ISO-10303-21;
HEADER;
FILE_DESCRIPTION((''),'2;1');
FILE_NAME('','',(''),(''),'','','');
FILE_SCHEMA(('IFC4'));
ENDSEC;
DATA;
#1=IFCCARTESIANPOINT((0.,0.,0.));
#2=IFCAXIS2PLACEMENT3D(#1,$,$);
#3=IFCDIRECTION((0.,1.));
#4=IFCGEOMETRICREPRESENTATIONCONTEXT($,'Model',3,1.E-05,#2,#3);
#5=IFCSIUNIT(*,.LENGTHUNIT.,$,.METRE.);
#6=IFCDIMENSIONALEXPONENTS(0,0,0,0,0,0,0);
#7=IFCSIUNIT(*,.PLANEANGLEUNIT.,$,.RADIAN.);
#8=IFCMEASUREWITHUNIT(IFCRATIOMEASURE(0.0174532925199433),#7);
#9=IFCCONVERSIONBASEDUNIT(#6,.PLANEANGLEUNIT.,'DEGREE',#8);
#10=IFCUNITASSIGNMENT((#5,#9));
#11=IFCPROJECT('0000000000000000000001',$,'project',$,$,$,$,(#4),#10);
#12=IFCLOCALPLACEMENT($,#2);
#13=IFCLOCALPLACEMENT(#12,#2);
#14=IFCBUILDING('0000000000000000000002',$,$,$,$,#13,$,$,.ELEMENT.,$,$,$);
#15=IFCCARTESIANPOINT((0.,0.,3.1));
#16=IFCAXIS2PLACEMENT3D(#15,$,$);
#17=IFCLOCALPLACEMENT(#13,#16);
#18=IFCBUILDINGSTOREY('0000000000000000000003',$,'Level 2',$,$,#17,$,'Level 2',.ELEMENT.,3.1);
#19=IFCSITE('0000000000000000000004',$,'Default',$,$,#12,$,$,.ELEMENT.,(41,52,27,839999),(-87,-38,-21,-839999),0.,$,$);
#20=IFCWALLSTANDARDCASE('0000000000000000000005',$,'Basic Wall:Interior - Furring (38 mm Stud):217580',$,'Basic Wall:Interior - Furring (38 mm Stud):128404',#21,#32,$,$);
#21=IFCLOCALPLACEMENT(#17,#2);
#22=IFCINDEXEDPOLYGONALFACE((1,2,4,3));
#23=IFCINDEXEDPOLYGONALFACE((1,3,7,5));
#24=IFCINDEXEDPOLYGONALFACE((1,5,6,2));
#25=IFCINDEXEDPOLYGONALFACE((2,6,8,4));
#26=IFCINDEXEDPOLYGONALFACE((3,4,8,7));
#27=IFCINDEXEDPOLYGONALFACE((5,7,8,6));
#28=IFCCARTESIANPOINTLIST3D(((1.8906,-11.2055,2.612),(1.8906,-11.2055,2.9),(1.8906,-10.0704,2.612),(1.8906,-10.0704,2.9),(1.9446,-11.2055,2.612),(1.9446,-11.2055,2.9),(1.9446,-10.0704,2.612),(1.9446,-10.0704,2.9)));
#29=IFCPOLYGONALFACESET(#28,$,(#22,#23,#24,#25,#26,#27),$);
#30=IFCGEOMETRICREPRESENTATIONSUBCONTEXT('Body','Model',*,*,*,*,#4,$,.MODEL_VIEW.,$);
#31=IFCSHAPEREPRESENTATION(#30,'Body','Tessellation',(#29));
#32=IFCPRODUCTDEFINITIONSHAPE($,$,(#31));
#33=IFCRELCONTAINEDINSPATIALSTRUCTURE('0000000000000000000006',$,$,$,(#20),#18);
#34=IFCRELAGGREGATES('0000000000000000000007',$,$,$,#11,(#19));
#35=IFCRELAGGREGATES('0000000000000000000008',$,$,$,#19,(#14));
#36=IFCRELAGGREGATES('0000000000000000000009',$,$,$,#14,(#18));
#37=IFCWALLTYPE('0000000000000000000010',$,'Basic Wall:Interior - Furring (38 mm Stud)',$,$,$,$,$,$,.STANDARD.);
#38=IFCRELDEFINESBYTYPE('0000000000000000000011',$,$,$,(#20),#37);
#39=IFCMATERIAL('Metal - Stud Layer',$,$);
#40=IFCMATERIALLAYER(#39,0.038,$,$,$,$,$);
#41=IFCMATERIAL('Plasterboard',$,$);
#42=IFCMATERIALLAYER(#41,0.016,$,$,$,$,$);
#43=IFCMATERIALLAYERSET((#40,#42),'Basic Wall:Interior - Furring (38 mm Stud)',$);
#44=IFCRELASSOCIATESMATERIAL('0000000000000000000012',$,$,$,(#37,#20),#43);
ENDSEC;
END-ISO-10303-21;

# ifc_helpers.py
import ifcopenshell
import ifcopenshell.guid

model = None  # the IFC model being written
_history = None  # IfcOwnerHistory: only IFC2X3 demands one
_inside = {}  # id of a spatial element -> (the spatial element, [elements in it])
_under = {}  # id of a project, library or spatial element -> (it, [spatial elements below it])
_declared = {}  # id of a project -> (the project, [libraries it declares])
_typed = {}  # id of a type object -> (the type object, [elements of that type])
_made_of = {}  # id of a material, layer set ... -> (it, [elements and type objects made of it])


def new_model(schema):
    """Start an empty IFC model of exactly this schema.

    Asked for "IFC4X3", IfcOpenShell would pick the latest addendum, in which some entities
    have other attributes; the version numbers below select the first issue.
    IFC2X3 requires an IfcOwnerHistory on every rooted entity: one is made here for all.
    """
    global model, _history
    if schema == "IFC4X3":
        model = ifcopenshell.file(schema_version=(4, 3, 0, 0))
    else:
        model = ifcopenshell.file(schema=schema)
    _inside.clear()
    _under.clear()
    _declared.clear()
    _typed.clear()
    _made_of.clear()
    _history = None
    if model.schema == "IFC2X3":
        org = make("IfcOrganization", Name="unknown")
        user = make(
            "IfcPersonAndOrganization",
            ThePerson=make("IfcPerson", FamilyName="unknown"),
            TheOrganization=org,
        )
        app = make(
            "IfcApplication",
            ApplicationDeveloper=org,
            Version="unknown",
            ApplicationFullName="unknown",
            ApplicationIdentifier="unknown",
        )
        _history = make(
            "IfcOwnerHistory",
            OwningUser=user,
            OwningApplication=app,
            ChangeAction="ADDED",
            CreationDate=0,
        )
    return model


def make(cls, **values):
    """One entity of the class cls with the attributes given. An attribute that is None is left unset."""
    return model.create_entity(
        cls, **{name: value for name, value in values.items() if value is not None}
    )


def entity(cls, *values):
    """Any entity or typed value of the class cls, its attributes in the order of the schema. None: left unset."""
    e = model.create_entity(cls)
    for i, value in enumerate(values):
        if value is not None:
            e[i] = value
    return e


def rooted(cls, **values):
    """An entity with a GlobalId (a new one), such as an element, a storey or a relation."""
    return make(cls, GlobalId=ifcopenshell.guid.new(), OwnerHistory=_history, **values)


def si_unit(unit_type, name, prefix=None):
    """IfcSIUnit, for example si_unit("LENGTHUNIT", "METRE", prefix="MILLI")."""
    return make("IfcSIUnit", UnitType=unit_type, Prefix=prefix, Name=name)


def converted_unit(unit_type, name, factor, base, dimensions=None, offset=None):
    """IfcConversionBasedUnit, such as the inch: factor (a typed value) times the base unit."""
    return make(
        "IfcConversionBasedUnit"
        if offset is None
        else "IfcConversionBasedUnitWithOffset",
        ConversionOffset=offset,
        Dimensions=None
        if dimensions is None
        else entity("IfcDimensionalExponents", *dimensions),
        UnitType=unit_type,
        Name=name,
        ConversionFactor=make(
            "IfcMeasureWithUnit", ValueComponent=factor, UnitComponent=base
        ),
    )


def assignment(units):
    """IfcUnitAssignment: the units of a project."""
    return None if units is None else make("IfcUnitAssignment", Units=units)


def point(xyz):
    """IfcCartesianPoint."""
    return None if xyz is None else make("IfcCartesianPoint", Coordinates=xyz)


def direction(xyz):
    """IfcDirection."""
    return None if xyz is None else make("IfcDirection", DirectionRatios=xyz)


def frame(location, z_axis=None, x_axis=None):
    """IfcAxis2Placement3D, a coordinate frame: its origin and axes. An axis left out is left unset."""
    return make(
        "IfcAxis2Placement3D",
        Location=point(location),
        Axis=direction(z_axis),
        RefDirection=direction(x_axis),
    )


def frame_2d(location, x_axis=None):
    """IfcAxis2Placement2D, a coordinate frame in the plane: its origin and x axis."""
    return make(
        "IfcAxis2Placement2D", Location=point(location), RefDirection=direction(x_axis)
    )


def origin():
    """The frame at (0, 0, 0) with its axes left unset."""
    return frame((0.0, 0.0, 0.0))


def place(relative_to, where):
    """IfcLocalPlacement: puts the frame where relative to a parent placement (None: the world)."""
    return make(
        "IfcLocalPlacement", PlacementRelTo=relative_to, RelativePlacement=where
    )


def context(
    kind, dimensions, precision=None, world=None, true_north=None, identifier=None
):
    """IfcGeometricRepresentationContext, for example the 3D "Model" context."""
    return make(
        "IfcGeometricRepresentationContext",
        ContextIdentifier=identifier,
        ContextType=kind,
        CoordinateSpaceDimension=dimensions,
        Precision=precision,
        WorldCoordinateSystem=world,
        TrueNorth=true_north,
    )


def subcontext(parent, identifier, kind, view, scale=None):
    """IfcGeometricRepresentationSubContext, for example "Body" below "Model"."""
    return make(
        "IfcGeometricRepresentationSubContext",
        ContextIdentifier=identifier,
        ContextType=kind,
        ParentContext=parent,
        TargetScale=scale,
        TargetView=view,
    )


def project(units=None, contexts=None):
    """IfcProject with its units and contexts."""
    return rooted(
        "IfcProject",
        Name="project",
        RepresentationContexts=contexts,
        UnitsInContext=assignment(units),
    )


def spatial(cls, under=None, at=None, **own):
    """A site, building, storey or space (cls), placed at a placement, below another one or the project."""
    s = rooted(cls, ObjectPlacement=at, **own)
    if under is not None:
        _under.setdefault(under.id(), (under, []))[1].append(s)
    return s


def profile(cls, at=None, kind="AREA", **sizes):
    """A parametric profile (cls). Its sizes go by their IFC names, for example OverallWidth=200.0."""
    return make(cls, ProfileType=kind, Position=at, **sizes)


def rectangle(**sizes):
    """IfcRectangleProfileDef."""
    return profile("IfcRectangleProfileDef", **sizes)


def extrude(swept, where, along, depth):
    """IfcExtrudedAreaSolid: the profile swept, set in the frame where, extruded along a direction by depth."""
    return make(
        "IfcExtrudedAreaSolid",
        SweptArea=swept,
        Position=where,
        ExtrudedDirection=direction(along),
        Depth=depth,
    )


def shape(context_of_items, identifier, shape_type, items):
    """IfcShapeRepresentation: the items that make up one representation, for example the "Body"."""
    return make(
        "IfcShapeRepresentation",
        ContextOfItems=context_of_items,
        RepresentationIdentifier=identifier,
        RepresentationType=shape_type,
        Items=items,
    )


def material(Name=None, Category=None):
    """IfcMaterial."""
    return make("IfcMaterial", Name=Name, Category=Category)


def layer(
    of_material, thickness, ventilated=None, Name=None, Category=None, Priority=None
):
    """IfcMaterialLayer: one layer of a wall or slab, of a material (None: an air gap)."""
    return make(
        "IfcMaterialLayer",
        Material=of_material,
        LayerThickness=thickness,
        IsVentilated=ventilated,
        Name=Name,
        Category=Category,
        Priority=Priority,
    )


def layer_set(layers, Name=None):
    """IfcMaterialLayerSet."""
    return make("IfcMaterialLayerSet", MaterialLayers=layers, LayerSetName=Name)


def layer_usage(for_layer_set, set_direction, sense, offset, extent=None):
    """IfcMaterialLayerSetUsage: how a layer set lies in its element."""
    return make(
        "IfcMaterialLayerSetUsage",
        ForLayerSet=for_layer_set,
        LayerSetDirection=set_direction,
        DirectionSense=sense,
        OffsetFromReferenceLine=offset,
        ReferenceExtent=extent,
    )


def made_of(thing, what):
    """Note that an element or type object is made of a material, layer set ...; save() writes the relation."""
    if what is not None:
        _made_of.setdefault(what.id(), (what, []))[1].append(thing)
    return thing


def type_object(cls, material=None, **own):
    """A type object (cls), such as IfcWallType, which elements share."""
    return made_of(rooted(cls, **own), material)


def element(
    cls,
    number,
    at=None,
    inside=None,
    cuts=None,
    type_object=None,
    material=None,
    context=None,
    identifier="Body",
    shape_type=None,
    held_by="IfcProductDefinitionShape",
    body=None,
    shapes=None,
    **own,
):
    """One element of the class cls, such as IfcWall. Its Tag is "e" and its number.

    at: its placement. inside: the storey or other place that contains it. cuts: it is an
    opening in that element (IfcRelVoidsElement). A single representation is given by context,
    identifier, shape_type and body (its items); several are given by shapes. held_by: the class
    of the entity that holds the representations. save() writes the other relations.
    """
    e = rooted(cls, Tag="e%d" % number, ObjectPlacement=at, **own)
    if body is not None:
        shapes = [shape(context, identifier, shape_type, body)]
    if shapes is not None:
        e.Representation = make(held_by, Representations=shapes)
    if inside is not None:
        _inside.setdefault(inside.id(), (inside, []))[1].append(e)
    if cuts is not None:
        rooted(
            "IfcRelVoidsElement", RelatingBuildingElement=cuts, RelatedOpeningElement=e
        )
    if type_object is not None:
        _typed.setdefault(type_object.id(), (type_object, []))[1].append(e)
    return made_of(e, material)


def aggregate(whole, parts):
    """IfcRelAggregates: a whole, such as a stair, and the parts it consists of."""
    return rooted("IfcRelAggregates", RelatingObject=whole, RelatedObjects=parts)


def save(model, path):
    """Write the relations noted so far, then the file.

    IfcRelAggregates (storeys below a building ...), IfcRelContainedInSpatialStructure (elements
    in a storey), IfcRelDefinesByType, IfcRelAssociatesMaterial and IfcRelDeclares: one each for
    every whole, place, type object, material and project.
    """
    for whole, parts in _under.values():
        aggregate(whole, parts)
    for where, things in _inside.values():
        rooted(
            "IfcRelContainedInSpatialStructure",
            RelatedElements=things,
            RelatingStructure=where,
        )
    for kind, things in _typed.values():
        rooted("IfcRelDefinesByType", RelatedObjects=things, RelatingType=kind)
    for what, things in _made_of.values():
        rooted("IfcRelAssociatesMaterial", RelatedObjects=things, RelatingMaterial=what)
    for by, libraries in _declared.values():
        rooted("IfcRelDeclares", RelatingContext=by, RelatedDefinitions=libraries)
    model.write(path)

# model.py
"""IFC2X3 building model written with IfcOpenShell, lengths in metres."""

from ifc_helpers import new_model, entity, si_unit, converted_unit, direction, frame, frame_2d, origin, place, context, subcontext, project, spatial, rectangle, extrude, material, layer, layer_set, layer_usage, type_object, element, save


model = new_model("IFC2X3")

# Units and contexts
model_context = context("Model", 3, precision=1e-05, world=origin(), true_north=direction((0.0, 1.0)))
body_context = subcontext(model_context, "Body", "Model", "MODEL_VIEW")
ifc_project = project(units=[si_unit("LENGTHUNIT", "METRE"), converted_unit("PLANEANGLEUNIT", "DEGREE", entity("IfcRatioMeasure", 0.0174532925199433), si_unit("PLANEANGLEUNIT", "RADIAN"), dimensions=[0, 0, 0, 0, 0, 0, 0])], contexts=[model_context])

# Site, building, storey
site_placement = place(None, origin())
site = spatial("IfcSite", under=ifc_project, at=site_placement, Name="Default", CompositionType="ELEMENT", RefLatitude=(41, 52, 27, 839999), RefLongitude=(-87, -38, -21, -839999), RefElevation=0.0)
building_placement = place(site_placement, origin())
building = spatial("IfcBuilding", under=site, at=building_placement, CompositionType="ELEMENT")
storey_placement = place(building_placement, frame((0.0, 0.0, 3.1)))
storey = spatial("IfcBuildingStorey", under=building, at=storey_placement, Name="Level 2", LongName="Level 2", CompositionType="ELEMENT", Elevation=3.1)

# Shared definitions
ifc_material_1 = material(Name="Plasterboard")
ifc_material_2 = material(Name="Metal - Stud Layer")

# Wall
ifc_layer_1 = layer(ifc_material_2, 0.038)
ifc_layer_2 = layer(ifc_material_1, 0.016)
ifc_layer_set_1 = layer_set([ifc_layer_1, ifc_layer_2], Name="Basic Wall:Interior - Furring (38 mm Stud)")
wall_type_1 = type_object("IfcWallType", Name="Basic Wall:Interior - Furring (38 mm Stud)", PredefinedType="STANDARD", material=ifc_layer_set_1)
ifc_layer_usage_1 = layer_usage(ifc_layer_set_1, "AXIS2", "NEGATIVE", 0.027)
wall_1_placement = place(storey_placement, frame((1.9176, -10.0704, 2.612), z_axis=(0.0, 0.0, 1.0), x_axis=(0.0, -1.0, 0.0)))
element("IfcWallStandardCase", 1, at=wall_1_placement, inside=storey, type_object=wall_type_1, material=ifc_layer_usage_1, Name="Basic Wall:Interior - Furring (38 mm Stud):217580", ObjectType="Basic Wall:Interior - Furring (38 mm Stud):128404", context=body_context, shape_type="SweptSolid", body=[
    extrude(rectangle(XDim=1.1351, YDim=0.054, at=frame_2d((0.5675, 0.0), x_axis=(-1.0, 0.0))), origin(), (0.0, 0.0, 1.0), 0.288),
])

save(model, "model.ifc")
